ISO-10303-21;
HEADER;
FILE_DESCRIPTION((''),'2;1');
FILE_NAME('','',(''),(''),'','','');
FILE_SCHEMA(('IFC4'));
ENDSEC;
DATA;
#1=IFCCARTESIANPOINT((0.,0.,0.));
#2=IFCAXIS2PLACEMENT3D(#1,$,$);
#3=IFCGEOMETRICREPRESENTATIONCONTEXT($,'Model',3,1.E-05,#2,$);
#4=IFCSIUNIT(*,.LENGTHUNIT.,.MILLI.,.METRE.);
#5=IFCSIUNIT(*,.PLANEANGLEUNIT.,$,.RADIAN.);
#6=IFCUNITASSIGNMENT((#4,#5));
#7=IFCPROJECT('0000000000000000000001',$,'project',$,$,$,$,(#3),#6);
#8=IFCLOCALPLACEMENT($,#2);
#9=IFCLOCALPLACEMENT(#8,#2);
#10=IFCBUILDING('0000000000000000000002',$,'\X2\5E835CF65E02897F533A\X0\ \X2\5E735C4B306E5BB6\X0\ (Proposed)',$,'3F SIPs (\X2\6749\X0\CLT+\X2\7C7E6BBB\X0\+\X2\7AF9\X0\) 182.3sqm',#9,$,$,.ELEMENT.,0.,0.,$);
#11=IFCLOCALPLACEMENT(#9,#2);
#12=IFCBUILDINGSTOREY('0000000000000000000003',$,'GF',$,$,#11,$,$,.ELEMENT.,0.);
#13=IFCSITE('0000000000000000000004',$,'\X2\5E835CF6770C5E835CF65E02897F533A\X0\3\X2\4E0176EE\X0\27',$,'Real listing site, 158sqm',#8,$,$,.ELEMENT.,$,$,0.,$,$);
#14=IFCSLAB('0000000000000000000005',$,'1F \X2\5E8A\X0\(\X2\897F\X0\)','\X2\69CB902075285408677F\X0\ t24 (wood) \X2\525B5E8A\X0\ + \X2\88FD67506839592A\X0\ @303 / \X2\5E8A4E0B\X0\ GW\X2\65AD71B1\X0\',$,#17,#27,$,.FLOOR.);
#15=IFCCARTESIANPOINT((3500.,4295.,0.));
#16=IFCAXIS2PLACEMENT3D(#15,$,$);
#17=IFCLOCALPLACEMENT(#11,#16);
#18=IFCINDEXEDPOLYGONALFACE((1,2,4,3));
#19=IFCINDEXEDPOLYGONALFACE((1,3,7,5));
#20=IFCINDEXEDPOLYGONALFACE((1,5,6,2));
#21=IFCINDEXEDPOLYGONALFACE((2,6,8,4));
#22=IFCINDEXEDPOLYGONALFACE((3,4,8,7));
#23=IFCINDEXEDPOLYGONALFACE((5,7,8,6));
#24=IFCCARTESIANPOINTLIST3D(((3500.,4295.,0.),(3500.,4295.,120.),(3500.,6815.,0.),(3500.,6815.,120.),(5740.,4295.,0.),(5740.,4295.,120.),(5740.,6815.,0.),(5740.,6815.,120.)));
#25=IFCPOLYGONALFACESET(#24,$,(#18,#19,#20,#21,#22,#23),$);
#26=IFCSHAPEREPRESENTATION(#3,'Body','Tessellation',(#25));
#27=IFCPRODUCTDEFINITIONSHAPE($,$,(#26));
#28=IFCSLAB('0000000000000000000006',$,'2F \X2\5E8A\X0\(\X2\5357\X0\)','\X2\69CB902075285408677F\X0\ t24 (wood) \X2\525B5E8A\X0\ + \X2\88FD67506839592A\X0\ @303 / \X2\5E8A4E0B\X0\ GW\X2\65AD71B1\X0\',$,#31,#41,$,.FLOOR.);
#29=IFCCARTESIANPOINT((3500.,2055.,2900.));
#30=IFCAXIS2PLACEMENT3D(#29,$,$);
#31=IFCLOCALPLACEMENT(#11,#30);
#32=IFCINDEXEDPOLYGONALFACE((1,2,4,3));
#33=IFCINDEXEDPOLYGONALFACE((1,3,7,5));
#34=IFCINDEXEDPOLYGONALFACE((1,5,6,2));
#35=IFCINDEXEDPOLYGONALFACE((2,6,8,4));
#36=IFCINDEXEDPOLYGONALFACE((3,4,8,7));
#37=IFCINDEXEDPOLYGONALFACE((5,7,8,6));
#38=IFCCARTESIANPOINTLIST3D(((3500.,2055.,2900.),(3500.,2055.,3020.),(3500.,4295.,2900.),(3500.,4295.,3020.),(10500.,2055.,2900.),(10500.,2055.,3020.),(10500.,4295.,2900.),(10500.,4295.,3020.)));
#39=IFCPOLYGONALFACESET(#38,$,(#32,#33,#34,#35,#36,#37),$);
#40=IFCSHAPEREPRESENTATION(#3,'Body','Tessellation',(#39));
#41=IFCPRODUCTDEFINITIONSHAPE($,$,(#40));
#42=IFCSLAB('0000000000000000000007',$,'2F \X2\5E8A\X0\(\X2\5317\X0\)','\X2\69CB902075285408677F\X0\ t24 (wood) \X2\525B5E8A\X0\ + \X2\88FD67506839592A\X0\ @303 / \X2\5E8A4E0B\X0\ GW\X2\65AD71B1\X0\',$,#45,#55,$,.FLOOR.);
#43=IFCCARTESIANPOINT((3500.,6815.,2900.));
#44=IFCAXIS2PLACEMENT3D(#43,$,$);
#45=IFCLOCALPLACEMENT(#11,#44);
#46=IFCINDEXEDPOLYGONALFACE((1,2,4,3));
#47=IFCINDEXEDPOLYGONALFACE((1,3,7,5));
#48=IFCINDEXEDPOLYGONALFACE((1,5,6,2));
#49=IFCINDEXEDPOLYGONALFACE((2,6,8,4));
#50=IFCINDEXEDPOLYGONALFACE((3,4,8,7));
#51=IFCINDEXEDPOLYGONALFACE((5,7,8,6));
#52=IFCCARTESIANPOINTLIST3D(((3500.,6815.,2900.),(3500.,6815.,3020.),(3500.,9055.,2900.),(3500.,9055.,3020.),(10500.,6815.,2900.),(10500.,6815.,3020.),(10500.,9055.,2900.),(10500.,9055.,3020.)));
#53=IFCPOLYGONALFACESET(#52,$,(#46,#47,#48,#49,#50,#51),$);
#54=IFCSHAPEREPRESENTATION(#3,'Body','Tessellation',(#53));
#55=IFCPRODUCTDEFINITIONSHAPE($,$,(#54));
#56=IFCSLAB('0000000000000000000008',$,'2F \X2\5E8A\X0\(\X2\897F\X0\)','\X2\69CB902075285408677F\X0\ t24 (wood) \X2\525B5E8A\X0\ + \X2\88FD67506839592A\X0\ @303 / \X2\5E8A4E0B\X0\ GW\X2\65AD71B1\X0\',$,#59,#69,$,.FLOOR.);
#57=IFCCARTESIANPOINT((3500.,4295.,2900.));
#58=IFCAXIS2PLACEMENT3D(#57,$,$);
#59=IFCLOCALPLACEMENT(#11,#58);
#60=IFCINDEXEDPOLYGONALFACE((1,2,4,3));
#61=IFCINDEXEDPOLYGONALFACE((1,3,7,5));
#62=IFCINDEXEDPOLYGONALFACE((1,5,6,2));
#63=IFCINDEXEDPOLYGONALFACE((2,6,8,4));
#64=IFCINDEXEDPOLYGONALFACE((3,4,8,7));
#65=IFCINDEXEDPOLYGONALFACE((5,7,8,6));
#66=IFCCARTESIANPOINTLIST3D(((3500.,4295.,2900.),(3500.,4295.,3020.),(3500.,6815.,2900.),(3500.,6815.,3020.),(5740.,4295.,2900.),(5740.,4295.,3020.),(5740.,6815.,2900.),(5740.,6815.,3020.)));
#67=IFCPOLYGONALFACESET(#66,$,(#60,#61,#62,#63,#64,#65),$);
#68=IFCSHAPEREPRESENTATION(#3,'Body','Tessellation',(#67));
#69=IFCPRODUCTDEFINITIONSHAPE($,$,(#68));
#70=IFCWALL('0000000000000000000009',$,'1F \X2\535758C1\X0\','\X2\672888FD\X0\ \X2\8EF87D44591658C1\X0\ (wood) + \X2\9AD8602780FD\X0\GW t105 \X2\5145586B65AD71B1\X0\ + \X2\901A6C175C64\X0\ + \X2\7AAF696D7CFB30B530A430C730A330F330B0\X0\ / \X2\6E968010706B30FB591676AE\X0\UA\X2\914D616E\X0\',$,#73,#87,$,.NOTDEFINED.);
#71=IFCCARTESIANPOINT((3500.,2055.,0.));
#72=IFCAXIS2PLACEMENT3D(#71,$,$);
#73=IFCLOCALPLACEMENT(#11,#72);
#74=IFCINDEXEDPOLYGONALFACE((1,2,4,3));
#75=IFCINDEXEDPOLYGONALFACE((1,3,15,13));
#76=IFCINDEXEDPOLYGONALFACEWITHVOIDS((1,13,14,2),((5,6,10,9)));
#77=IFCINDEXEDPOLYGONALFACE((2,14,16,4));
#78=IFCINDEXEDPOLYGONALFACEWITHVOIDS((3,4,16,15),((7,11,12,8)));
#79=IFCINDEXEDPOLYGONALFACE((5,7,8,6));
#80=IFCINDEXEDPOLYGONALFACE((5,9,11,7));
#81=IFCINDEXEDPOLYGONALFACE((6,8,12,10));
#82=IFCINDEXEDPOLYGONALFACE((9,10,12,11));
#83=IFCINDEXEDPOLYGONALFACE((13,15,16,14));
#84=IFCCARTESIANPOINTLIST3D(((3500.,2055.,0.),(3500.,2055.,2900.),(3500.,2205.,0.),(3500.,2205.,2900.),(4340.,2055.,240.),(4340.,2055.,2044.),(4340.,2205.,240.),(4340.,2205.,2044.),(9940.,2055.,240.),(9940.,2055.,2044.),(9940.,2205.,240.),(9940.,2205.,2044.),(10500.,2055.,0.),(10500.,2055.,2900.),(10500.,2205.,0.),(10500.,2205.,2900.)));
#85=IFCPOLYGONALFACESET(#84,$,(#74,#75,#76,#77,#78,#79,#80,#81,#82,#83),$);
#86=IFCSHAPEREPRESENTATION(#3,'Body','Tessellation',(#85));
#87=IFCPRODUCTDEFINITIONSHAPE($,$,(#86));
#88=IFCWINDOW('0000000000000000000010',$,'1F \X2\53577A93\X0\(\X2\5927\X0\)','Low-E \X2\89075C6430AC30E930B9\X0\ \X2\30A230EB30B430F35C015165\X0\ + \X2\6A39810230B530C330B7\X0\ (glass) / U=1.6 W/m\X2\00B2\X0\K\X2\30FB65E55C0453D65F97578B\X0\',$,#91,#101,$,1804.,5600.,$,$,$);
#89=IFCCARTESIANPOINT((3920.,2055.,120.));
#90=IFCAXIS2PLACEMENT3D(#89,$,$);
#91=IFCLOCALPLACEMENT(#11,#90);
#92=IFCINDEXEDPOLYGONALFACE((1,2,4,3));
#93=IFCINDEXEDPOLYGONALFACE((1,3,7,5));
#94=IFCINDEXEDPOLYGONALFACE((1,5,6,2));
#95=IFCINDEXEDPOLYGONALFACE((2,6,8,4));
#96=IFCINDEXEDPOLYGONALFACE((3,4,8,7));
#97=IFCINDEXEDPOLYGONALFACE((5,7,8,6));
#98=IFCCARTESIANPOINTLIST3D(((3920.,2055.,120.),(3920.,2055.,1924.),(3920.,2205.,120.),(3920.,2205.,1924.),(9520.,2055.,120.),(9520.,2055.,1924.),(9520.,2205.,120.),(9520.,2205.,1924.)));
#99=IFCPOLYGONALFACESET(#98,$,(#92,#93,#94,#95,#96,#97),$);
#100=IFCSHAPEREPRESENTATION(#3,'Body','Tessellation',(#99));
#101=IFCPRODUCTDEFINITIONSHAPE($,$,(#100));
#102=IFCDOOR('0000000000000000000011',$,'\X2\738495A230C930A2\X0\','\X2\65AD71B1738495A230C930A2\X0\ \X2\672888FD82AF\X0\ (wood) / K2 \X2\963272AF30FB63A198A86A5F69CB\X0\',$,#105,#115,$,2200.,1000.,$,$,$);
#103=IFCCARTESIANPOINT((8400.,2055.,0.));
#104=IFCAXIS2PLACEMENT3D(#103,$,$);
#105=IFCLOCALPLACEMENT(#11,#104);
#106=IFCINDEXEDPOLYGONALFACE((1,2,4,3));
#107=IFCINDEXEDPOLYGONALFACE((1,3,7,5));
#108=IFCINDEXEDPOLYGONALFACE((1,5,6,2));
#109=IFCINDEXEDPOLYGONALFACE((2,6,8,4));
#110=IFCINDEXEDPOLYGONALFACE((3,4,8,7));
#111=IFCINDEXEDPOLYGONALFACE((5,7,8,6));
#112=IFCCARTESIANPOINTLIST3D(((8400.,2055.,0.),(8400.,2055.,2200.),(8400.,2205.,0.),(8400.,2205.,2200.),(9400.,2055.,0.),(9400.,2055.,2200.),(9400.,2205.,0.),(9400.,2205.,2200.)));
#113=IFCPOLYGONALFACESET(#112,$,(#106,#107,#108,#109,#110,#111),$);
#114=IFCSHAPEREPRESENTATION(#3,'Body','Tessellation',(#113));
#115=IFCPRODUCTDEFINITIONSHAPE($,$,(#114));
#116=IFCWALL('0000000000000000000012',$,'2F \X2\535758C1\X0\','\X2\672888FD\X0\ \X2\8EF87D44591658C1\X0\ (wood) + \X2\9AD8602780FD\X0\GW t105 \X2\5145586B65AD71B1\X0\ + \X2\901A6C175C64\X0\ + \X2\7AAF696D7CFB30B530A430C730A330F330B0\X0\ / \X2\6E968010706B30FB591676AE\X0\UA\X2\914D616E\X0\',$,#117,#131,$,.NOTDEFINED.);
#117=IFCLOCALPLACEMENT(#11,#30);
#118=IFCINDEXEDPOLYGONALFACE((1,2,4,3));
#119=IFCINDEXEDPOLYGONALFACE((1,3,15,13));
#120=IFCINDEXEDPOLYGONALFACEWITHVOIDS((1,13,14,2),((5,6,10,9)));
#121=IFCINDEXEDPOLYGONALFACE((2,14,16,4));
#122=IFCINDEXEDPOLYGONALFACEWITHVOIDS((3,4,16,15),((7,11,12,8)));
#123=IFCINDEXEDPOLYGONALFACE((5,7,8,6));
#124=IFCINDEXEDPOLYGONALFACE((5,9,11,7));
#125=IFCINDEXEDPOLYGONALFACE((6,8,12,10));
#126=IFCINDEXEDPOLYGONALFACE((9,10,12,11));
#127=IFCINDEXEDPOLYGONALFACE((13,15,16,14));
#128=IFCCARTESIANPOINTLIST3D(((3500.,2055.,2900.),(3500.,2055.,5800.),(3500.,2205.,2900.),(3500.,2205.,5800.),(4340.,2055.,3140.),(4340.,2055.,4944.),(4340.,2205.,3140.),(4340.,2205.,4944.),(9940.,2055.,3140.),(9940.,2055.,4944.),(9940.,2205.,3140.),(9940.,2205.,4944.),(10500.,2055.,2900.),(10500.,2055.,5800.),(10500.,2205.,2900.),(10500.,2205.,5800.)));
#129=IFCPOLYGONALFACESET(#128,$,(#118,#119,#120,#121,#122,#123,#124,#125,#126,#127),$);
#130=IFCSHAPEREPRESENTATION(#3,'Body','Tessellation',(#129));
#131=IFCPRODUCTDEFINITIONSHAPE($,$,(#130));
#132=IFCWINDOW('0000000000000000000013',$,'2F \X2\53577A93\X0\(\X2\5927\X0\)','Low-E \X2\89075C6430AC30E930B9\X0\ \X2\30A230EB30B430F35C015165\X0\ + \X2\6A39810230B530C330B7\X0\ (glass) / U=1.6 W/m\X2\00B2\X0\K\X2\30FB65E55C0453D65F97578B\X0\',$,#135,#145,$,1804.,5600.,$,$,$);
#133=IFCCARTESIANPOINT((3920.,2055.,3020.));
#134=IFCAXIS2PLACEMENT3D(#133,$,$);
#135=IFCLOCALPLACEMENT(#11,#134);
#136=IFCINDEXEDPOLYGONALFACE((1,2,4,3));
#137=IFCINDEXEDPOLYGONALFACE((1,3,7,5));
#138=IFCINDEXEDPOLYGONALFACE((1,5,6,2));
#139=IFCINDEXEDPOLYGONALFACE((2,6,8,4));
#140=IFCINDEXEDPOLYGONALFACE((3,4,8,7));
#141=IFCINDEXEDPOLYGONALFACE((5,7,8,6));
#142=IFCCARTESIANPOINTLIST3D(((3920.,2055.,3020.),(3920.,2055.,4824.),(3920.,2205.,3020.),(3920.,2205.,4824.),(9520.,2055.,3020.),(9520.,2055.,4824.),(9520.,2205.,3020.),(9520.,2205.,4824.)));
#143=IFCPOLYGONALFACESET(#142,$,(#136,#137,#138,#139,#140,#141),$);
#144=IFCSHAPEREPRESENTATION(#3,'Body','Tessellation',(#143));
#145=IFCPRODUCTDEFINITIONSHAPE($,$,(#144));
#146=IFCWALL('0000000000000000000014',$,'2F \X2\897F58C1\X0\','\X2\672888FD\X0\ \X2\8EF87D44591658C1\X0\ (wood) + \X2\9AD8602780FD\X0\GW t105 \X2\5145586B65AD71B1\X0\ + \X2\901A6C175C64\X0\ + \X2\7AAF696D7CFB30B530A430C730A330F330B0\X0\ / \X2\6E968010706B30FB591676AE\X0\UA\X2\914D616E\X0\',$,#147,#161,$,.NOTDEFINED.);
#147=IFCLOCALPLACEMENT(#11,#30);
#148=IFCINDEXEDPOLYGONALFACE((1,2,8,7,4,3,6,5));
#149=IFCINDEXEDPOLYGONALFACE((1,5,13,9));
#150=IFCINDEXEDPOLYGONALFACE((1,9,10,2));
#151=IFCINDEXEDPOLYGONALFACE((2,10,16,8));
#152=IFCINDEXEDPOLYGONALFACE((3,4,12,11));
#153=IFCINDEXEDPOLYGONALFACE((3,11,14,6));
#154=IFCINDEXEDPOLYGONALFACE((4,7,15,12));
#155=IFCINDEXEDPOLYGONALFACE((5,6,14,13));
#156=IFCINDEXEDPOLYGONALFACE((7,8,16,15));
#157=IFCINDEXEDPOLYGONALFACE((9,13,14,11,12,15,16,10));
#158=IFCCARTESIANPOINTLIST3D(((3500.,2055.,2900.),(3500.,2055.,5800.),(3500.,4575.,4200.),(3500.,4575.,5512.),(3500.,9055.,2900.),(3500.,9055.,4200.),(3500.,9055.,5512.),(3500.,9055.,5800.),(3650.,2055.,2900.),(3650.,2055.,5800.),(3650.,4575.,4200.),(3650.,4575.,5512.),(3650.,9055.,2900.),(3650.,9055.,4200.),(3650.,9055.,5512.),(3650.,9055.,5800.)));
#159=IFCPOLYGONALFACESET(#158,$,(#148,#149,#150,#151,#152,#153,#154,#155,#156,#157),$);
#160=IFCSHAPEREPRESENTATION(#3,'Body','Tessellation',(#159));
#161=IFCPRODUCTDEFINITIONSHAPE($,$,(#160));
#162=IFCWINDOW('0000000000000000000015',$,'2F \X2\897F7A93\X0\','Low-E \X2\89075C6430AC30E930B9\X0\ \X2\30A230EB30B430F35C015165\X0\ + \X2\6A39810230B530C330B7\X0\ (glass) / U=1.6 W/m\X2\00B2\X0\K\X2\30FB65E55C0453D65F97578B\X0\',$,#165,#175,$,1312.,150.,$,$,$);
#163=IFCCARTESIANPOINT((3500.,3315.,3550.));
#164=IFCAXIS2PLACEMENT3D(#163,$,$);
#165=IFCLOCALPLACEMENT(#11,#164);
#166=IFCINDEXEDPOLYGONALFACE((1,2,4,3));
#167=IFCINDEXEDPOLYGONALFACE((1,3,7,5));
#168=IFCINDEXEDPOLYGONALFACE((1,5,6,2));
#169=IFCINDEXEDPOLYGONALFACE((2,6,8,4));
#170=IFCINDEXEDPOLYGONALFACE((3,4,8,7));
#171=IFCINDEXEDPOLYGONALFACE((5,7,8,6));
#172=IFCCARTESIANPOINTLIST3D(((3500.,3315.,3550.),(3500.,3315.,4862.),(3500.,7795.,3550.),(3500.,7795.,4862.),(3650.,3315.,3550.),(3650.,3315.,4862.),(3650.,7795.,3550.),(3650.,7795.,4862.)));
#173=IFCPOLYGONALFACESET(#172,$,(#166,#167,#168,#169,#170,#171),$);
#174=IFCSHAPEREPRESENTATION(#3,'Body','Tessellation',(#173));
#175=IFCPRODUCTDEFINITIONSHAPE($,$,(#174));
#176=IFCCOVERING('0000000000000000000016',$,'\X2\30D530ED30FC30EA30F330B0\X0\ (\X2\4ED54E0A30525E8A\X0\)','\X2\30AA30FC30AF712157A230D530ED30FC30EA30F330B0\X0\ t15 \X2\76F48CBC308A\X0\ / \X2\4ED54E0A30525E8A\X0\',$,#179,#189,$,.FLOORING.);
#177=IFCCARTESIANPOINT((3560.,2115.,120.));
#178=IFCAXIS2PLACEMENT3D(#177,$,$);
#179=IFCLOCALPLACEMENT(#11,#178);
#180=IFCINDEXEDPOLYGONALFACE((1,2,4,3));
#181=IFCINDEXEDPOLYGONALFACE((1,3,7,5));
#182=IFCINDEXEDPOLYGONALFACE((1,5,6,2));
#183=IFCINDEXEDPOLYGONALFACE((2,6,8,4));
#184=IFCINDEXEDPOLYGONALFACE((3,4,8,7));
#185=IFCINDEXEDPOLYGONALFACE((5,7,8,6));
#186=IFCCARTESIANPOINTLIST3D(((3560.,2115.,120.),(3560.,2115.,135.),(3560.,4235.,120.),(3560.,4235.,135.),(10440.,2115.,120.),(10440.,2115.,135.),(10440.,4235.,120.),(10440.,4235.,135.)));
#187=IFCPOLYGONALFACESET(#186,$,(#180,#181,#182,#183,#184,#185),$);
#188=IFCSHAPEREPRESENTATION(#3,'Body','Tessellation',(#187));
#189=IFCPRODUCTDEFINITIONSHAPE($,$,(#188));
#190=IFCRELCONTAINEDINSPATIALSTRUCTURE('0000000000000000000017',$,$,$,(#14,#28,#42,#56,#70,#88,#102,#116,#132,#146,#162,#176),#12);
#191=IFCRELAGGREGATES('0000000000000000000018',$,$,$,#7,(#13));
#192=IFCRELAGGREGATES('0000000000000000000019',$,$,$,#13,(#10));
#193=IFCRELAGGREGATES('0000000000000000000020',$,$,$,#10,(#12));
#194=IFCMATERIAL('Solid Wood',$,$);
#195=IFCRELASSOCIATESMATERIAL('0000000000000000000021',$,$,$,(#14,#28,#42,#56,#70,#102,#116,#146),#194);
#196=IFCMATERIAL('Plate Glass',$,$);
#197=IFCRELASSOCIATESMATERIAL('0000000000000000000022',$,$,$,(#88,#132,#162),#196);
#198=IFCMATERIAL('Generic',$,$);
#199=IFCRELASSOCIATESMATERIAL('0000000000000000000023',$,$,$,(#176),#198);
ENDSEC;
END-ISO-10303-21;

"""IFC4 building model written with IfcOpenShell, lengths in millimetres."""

from ifc_helpers import new_model, si_unit, frame, frame_2d, origin, place, context, project, spatial, rectangle, extrude, material, element, fill, save


model = new_model("IFC4")

# Units and contexts
model_context = context("Model", 3, precision=1e-05, world=origin())
ifc_project = project(units=[si_unit("LENGTHUNIT", "METRE", prefix="MILLI"), si_unit("PLANEANGLEUNIT", "RADIAN")], contexts=[model_context])

# Site, building, storey
site_placement = place(None, origin())
site = spatial("IfcSite", under=ifc_project, at=site_placement, Name="広島県広島市西区3丁目27", ObjectType="Real listing site, 158sqm", CompositionType="ELEMENT", RefElevation=0.0)
building_placement = place(site_placement, origin())
building = spatial("IfcBuilding", under=site, at=building_placement, Name="広島市西区 平屋の家 (Proposed)", ObjectType="3F SIPs (杉CLT+籾殻+竹) 182.3sqm", CompositionType="ELEMENT", ElevationOfRefHeight=0.0, ElevationOfTerrain=0.0)
storey_placement = place(building_placement, origin())
storey = spatial("IfcBuildingStorey", under=building, at=storey_placement, Name="GF", CompositionType="ELEMENT", Elevation=0.0)

# Slabs
ifc_material_1 = material(Name="Solid Wood")
slab_1_placement = place(storey_placement, frame((3500.0, 4295.0, 0.0)))
element("IfcSlab", 1, at=slab_1_placement, inside=storey, material=ifc_material_1, Name="1F 床(西)", Description="構造用合板 t24 (wood) 剛床 + 製材根太 @303 / 床下 GW断熱", PredefinedType="FLOOR", context=model_context, shape_type="SweptSolid", body=[
    extrude(rectangle(XDim=2240.0, YDim=2520.0, at=frame_2d((1120.0, 1260.0))), frame((3500.0, 4295.0, 0.0)), (0.0, 0.0, 1.0), 120.0),
])
slab_2_placement = place(storey_placement, frame((3500.0, 2055.0, 2900.0)))
element("IfcSlab", 2, at=slab_2_placement, inside=storey, material=ifc_material_1, Name="2F 床(南)", Description="構造用合板 t24 (wood) 剛床 + 製材根太 @303 / 床下 GW断熱", PredefinedType="FLOOR", context=model_context, shape_type="SweptSolid", body=[
    extrude(rectangle(XDim=7000.0, YDim=2240.0, at=frame_2d((3500.0, 1120.0))), frame((3500.0, 2055.0, 2900.0)), (0.0, 0.0, 1.0), 120.0),
])
slab_3_placement = place(storey_placement, frame((3500.0, 6815.0, 2900.0)))
element("IfcSlab", 3, at=slab_3_placement, inside=storey, material=ifc_material_1, Name="2F 床(北)", Description="構造用合板 t24 (wood) 剛床 + 製材根太 @303 / 床下 GW断熱", PredefinedType="FLOOR", context=model_context, shape_type="SweptSolid", body=[
    extrude(rectangle(XDim=7000.0, YDim=2240.0, at=frame_2d((3500.0, 1120.0))), frame((3500.0, 6815.0, 2900.0)), (0.0, 0.0, 1.0), 120.0),
])
slab_4_placement = place(storey_placement, frame((3500.0, 4295.0, 2900.0)))
element("IfcSlab", 4, at=slab_4_placement, inside=storey, material=ifc_material_1, Name="2F 床(西)", Description="構造用合板 t24 (wood) 剛床 + 製材根太 @303 / 床下 GW断熱", PredefinedType="FLOOR", context=model_context, shape_type="SweptSolid", body=[
    extrude(rectangle(XDim=2240.0, YDim=2520.0, at=frame_2d((1120.0, 1260.0))), frame((3500.0, 4295.0, 2900.0)), (0.0, 0.0, 1.0), 120.0),
])

# Wall, openings, window, door
wall_1_placement = place(storey_placement, frame((3500.0, 2055.0, 0.0)))
wall_1 = element("IfcWall", 5, at=wall_1_placement, inside=storey, material=ifc_material_1, Name="1F 南壁", Description="木製 軸組外壁 (wood) + 高性能GW t105 充填断熱 + 通気層 + 窯業系サイディング / 準耐火・外皮UA配慮", PredefinedType="NOTDEFINED", context=model_context, shape_type="SweptSolid", body=[
    extrude(rectangle(XDim=7000.0, YDim=150.0, at=frame_2d((3500.0, 75.0))), frame((3500.0, 2055.0, 0.0)), (0.0, 0.0, 1.0), 2900.0),
])
opening_1_placement = place(storey_placement, frame((3920.0, 2055.0, 120.0)))
opening_1 = element("IfcOpeningElement", 6, at=opening_1_placement, cuts=wall_1, PredefinedType="NOTDEFINED", context=model_context, shape_type="SweptSolid", body=[
    extrude(rectangle(XDim=5600.0, YDim=150.0, at=frame_2d((2800.0, 75.0))), frame((3920.0, 2055.0, 120.0)), (0.0, 0.0, 1.0), 1804.0),
])
opening_2_placement = place(storey_placement, frame((8400.0, 2055.0, 0.0)))
opening_2 = element("IfcOpeningElement", 7, at=opening_2_placement, cuts=wall_1, PredefinedType="NOTDEFINED", context=model_context, shape_type="SweptSolid", body=[
    extrude(rectangle(XDim=1000.0, YDim=150.0, at=frame_2d((500.0, 75.0))), frame((8400.0, 2055.0, 0.0)), (0.0, 0.0, 1.0), 2200.0),
])
ifc_material_2 = material(Name="Plate Glass")
window_1_placement = place(storey_placement, frame((3920.0, 2055.0, 120.0)))
window_1 = element("IfcWindow", 8, at=window_1_placement, inside=storey, material=ifc_material_2, Name="1F 南窓(大)", Description="Low-E 複層ガラス アルゴン封入 + 樹脂サッシ (glass) / U=1.6 W/m²K・日射取得型", OverallHeight=1804.0, OverallWidth=5600.0, context=model_context, shape_type="SweptSolid", body=[
    extrude(rectangle(XDim=5600.0, YDim=150.0, at=frame_2d((2800.0, 75.0))), frame((3920.0, 2055.0, 120.0)), (0.0, 0.0, 1.0), 1804.0),
])
fill(opening_1, window_1)
door_placement = place(storey_placement, frame((8400.0, 2055.0, 0.0)))
door = element("IfcDoor", 9, at=door_placement, inside=storey, material=ifc_material_1, Name="玄関ドア", Description="断熱玄関ドア 木製芯 (wood) / K2 防犯・採風機構", OverallHeight=2200.0, OverallWidth=1000.0, context=model_context, shape_type="SweptSolid", body=[
    extrude(rectangle(XDim=1000.0, YDim=150.0, at=frame_2d((500.0, 75.0))), frame((8400.0, 2055.0, 0.0)), (0.0, 0.0, 1.0), 2200.0),
])
fill(opening_2, door)

# Wall, opening, window
wall_2_placement = place(storey_placement, frame((3500.0, 2055.0, 2900.0)))
wall_2 = element("IfcWall", 10, at=wall_2_placement, inside=storey, material=ifc_material_1, Name="2F 南壁", Description="木製 軸組外壁 (wood) + 高性能GW t105 充填断熱 + 通気層 + 窯業系サイディング / 準耐火・外皮UA配慮", PredefinedType="NOTDEFINED", context=model_context, shape_type="SweptSolid", body=[
    extrude(rectangle(XDim=7000.0, YDim=150.0, at=frame_2d((3500.0, 75.0))), frame((3500.0, 2055.0, 2900.0)), (0.0, 0.0, 1.0), 2900.0),
])
opening_3_placement = place(storey_placement, frame((3920.0, 2055.0, 3020.0)))
opening_3 = element("IfcOpeningElement", 11, at=opening_3_placement, cuts=wall_2, PredefinedType="NOTDEFINED", context=model_context, shape_type="SweptSolid", body=[
    extrude(rectangle(XDim=5600.0, YDim=150.0, at=frame_2d((2800.0, 75.0))), frame((3920.0, 2055.0, 3020.0)), (0.0, 0.0, 1.0), 1804.0),
])
window_2_placement = place(storey_placement, frame((3920.0, 2055.0, 3020.0)))
window_2 = element("IfcWindow", 12, at=window_2_placement, inside=storey, material=ifc_material_2, Name="2F 南窓(大)", Description="Low-E 複層ガラス アルゴン封入 + 樹脂サッシ (glass) / U=1.6 W/m²K・日射取得型", OverallHeight=1804.0, OverallWidth=5600.0, context=model_context, shape_type="SweptSolid", body=[
    extrude(rectangle(XDim=5600.0, YDim=150.0, at=frame_2d((2800.0, 75.0))), frame((3920.0, 2055.0, 3020.0)), (0.0, 0.0, 1.0), 1804.0),
])
fill(opening_3, window_2)

# Wall, opening, window
wall_3_placement = place(storey_placement, frame((3500.0, 2055.0, 2900.0)))
wall_3 = element("IfcWall", 13, at=wall_3_placement, inside=storey, material=ifc_material_1, Name="2F 西壁", Description="木製 軸組外壁 (wood) + 高性能GW t105 充填断熱 + 通気層 + 窯業系サイディング / 準耐火・外皮UA配慮", PredefinedType="NOTDEFINED", context=model_context, shape_type="SweptSolid", body=[
    extrude(rectangle(XDim=150.0, YDim=7000.0, at=frame_2d((75.0, 3500.0))), frame((3500.0, 2055.0, 2900.0)), (0.0, 0.0, 1.0), 2900.0),
])
opening_4_placement = place(storey_placement, frame((3500.0, 3315.0, 3550.0)))
opening_4 = element("IfcOpeningElement", 14, at=opening_4_placement, cuts=wall_3, PredefinedType="NOTDEFINED", context=model_context, shape_type="SweptSolid", body=[
    extrude(rectangle(XDim=150.0, YDim=4480.0, at=frame_2d((75.0, 2240.0))), frame((3500.0, 3315.0, 3550.0)), (0.0, 0.0, 1.0), 1312.0),
])
window_3_placement = place(storey_placement, frame((3500.0, 3315.0, 3550.0)))
window_3 = element("IfcWindow", 15, at=window_3_placement, inside=storey, material=ifc_material_2, Name="2F 西窓", Description="Low-E 複層ガラス アルゴン封入 + 樹脂サッシ (glass) / U=1.6 W/m²K・日射取得型", OverallHeight=1312.0, OverallWidth=150.0, context=model_context, shape_type="SweptSolid", body=[
    extrude(rectangle(XDim=150.0, YDim=4480.0, at=frame_2d((75.0, 2240.0))), frame((3500.0, 3315.0, 3550.0)), (0.0, 0.0, 1.0), 1312.0),
])
fill(opening_4, window_3)

# Covering
ifc_material_3 = material(Name="Generic")
covering_1_placement = place(storey_placement, frame((3560.0, 2115.0, 120.0)))
element("IfcCovering", 16, at=covering_1_placement, inside=storey, material=ifc_material_3, Name="フローリング (仕上げ床)", Description="オーク無垢フローリング t15 直貼り / 仕上げ床", PredefinedType="FLOORING", context=model_context, shape_type="SweptSolid", body=[
    extrude(rectangle(XDim=6880.0, YDim=2120.0, at=frame_2d((3440.0, 1060.0))), frame((3560.0, 2115.0, 120.0)), (0.0, 0.0, 1.0), 15.0),
])

save(model, "model.ifc")
